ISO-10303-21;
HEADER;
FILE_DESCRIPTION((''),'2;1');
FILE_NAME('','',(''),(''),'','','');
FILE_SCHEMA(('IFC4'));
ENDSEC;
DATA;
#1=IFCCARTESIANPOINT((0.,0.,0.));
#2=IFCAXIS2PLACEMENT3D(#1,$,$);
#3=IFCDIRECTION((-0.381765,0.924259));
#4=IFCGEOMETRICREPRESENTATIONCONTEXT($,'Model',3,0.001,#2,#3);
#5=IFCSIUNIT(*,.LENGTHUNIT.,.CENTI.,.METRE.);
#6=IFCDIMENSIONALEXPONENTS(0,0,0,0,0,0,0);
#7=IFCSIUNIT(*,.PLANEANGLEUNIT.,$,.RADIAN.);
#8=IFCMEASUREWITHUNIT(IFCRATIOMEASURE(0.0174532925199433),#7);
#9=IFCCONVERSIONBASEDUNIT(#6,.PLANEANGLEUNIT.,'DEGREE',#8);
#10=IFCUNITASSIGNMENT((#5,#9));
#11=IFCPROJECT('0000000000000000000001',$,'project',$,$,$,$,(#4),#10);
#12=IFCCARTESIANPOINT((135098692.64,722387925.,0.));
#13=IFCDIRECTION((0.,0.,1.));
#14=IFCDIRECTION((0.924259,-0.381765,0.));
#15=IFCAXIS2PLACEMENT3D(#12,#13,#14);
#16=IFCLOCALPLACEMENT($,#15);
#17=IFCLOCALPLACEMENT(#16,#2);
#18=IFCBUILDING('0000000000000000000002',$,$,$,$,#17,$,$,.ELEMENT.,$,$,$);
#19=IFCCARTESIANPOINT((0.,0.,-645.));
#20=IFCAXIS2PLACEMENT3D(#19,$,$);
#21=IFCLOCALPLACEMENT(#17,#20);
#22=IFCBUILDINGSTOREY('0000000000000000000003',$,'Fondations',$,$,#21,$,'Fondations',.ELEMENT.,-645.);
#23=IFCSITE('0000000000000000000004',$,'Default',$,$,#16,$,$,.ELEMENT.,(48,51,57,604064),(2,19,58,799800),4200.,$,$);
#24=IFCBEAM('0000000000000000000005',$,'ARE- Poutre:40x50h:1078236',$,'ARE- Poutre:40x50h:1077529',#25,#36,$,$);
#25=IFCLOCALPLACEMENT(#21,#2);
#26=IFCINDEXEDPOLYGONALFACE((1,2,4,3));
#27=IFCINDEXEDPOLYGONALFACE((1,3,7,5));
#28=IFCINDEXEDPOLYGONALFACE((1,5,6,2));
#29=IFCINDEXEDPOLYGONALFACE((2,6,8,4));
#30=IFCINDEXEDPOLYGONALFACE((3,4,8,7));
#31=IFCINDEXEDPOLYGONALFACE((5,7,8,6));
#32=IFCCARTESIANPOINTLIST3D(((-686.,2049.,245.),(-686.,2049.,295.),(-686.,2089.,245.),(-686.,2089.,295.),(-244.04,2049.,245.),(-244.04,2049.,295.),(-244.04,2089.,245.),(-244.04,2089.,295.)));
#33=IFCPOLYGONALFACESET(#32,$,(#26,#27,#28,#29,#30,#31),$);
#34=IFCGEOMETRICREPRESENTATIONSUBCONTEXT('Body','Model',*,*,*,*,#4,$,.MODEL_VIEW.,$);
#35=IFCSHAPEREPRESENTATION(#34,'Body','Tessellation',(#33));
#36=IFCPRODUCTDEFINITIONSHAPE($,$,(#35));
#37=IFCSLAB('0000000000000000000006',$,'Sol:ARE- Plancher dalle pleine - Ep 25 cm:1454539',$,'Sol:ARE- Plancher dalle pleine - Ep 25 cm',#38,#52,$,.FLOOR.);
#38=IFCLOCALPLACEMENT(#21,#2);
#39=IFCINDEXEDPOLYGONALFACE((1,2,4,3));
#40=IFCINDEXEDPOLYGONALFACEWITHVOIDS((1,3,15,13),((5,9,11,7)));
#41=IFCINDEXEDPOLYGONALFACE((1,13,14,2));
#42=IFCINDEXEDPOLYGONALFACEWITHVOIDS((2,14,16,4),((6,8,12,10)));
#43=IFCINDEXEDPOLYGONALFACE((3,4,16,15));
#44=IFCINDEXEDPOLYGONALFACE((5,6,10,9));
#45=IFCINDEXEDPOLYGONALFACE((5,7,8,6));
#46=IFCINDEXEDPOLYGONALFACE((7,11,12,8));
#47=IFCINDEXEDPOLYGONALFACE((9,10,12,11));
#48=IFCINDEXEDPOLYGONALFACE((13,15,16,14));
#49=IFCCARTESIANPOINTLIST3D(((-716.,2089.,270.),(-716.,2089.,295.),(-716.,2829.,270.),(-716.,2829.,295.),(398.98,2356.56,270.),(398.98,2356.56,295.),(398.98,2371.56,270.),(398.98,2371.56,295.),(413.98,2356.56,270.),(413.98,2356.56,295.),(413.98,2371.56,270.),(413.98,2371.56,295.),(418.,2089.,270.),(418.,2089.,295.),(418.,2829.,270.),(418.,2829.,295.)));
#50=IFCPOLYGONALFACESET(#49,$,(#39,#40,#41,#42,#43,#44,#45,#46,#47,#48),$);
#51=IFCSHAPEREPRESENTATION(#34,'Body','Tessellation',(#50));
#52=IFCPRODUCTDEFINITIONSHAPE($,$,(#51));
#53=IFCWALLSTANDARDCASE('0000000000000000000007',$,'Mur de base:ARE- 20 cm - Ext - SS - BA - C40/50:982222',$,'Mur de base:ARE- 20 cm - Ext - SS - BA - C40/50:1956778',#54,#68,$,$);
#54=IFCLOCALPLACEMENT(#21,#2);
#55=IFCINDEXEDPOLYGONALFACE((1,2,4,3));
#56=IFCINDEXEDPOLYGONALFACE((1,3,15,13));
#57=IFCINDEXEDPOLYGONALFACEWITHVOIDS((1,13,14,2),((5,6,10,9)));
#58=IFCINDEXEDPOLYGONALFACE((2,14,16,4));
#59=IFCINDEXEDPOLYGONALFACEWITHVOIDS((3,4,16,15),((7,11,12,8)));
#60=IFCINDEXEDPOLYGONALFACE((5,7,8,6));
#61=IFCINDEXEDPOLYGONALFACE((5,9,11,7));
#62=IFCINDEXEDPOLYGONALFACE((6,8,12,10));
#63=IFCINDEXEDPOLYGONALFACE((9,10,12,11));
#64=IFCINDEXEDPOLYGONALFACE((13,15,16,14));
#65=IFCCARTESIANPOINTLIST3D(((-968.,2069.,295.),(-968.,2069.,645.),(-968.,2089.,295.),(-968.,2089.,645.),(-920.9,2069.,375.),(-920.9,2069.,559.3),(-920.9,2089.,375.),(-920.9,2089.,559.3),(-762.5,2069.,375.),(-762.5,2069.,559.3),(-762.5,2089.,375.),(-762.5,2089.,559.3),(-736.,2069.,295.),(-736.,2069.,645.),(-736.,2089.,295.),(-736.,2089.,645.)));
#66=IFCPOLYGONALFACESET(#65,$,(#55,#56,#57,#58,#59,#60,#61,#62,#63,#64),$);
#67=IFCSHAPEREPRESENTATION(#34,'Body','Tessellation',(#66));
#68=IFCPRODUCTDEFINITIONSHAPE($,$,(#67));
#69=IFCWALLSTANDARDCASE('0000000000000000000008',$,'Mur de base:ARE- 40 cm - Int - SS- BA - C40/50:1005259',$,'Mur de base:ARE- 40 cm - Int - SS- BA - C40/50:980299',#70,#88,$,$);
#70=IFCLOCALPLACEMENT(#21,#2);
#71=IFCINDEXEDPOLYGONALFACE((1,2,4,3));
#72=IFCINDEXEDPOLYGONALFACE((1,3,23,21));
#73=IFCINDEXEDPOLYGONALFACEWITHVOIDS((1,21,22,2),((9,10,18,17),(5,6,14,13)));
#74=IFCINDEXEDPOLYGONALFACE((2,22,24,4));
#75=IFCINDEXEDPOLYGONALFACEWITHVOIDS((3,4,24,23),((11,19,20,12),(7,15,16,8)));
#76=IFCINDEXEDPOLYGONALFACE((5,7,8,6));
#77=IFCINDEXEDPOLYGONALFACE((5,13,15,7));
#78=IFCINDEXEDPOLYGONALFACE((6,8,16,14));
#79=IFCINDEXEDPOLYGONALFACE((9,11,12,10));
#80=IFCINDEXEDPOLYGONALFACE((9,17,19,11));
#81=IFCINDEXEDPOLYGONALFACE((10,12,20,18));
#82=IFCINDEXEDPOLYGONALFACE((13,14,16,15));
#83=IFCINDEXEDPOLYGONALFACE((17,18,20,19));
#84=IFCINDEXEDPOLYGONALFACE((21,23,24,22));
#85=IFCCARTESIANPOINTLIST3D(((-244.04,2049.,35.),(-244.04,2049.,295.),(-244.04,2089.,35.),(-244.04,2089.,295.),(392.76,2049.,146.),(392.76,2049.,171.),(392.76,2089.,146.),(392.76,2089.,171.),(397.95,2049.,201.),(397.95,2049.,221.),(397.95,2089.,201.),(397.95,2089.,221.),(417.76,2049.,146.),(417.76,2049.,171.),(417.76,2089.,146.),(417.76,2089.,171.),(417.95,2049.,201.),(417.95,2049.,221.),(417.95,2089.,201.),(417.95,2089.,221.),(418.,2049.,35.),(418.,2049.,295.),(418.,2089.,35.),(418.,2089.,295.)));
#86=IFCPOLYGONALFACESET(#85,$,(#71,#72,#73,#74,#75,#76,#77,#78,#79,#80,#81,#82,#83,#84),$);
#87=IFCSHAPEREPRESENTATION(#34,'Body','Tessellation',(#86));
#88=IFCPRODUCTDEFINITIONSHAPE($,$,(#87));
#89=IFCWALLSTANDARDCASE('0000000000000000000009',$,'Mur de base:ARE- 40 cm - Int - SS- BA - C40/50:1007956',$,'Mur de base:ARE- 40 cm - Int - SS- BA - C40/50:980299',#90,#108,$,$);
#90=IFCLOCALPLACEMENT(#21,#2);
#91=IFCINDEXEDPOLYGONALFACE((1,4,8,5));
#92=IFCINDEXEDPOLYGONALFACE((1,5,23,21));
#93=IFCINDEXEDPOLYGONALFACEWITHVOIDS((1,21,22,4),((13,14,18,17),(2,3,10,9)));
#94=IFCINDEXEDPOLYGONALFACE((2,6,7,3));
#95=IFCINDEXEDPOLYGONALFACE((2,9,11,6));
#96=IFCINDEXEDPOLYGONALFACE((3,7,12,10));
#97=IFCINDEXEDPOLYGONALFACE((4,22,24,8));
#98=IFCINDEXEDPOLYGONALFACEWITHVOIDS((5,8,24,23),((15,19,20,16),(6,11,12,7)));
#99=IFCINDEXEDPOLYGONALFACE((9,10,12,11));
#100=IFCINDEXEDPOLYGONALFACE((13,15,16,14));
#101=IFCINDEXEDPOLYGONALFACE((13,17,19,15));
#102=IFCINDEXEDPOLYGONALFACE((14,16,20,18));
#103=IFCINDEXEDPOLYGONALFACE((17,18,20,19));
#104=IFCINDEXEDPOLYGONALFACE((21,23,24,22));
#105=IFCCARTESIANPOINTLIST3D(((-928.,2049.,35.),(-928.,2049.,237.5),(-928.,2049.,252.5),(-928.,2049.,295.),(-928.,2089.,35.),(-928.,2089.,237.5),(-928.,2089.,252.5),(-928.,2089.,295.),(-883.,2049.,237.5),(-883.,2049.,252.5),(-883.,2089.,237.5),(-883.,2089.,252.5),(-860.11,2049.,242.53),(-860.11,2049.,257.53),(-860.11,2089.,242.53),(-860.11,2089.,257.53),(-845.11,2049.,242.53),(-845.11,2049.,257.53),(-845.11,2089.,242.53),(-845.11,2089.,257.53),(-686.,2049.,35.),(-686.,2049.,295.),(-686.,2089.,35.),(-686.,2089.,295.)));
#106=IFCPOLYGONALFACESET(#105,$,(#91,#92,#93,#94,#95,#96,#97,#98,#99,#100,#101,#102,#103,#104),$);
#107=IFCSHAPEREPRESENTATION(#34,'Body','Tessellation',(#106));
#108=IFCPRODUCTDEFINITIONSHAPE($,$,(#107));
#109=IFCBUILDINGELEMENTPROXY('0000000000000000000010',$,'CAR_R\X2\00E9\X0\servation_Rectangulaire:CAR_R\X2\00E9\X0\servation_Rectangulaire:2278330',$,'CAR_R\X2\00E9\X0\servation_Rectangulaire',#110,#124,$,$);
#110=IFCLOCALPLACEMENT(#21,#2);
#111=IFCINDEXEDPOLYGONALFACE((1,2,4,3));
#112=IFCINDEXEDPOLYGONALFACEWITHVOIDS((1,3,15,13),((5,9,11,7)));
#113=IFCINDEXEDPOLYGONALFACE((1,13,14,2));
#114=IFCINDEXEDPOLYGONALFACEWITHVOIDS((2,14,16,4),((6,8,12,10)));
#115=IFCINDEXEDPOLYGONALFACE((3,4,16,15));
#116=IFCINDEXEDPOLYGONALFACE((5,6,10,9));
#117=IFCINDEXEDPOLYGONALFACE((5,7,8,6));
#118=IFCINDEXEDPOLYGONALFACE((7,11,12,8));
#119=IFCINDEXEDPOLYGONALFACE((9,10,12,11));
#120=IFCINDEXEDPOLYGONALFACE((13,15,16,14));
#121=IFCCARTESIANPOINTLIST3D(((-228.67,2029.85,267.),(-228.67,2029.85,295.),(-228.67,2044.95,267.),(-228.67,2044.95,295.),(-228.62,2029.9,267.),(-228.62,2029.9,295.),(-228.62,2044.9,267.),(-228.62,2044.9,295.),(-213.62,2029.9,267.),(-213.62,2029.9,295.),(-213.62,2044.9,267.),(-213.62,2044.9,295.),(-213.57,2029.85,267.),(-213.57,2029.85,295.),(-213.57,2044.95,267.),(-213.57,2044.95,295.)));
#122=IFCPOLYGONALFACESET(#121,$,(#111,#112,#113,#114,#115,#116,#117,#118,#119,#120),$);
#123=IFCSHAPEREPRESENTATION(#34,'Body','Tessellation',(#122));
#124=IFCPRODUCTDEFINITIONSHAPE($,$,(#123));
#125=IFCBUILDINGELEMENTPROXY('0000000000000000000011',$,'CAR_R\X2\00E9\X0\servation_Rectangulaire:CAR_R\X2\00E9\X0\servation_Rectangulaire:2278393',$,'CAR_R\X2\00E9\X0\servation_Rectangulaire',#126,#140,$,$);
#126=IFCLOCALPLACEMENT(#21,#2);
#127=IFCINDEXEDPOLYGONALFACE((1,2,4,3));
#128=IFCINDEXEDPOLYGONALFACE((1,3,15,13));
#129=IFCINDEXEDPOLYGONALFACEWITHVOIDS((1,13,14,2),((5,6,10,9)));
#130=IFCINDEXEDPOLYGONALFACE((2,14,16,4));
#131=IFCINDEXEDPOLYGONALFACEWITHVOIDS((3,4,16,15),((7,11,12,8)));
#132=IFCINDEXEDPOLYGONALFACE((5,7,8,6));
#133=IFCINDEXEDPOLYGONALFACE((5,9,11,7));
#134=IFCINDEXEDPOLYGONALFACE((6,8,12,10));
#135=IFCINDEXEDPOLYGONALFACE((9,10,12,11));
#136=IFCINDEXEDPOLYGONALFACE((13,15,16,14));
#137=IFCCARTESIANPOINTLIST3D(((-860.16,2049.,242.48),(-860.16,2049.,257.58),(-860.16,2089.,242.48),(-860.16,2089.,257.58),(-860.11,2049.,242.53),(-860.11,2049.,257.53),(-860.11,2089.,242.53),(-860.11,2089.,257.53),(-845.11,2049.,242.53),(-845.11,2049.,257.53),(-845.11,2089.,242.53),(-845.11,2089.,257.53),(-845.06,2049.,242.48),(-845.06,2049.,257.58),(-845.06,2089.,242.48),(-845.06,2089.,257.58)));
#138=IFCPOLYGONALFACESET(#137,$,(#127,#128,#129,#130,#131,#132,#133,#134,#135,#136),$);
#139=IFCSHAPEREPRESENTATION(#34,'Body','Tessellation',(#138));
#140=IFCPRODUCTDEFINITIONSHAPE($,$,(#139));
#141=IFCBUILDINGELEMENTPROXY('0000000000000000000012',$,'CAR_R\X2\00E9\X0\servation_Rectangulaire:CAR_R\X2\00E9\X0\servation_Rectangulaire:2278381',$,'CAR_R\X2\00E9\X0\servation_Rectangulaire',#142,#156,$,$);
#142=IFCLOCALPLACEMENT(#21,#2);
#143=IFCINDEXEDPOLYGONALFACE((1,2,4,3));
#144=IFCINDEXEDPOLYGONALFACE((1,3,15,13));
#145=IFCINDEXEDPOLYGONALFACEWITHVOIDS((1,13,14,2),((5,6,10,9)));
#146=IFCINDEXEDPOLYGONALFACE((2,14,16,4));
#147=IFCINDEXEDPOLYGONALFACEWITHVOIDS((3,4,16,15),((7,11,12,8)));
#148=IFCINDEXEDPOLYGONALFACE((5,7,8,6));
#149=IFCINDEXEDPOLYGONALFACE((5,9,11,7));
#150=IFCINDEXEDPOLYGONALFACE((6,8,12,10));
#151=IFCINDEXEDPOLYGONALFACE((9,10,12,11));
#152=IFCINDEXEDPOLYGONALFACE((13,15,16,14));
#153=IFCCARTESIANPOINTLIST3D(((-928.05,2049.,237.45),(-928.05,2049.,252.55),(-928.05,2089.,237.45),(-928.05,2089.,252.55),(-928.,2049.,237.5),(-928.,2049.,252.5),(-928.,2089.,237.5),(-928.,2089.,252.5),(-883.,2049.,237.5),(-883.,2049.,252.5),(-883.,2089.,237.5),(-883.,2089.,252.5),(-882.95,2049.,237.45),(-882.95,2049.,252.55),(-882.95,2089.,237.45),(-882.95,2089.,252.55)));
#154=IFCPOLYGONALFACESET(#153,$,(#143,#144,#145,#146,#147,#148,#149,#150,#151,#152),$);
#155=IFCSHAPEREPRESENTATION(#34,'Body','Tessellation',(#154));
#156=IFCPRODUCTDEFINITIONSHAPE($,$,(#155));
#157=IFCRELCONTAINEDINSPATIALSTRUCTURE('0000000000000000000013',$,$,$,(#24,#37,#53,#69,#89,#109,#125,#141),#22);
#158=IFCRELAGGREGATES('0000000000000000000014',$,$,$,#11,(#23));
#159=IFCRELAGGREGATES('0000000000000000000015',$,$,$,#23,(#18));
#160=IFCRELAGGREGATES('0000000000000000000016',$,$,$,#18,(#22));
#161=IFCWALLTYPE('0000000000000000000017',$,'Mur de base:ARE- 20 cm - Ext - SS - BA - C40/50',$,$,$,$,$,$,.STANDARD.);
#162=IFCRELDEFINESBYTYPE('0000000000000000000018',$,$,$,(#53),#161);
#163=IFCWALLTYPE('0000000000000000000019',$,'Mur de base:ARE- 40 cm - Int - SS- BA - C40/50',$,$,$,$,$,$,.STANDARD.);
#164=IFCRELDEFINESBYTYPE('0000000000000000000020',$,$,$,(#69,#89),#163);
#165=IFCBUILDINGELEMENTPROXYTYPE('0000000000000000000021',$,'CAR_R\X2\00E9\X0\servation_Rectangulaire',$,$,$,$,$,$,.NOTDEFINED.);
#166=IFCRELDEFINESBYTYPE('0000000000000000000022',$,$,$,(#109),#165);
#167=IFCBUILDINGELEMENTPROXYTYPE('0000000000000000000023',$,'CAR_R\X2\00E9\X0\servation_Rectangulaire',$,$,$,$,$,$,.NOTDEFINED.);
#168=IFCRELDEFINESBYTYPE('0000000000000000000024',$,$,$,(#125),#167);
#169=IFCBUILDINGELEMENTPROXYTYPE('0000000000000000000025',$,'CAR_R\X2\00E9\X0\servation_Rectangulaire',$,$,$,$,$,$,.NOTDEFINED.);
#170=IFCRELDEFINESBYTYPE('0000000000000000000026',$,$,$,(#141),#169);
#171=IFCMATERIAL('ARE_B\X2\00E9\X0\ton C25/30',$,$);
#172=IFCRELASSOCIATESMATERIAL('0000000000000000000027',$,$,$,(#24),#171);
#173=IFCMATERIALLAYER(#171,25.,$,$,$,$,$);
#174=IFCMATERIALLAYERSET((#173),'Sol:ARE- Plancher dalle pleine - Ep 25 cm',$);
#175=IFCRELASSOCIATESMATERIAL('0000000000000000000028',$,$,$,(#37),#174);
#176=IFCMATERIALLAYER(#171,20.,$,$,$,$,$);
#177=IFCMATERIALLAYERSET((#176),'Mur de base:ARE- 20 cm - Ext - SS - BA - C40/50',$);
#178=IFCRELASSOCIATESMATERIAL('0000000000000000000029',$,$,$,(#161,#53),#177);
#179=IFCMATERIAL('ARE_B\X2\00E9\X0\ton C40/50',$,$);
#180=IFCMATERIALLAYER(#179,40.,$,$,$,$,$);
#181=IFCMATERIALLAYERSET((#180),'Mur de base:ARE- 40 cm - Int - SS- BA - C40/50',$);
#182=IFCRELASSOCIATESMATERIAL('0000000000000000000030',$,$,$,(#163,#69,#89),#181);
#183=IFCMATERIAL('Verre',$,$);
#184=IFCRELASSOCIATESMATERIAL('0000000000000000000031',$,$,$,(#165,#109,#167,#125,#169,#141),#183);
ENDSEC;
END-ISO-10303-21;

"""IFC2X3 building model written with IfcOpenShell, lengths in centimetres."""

from ifc_helpers import new_model, entity, si_unit, converted_unit, direction, frame, frame_2d, origin, origin_2d_with_axis, place, context, subcontext, project, spatial, polyline, rectangle, outline, extrude, source, transform, mapped, material, layer, layer_set, layer_usage, type_object, type_shapes, element, save


model = new_model("IFC2X3")

# Units and contexts
model_context = context("Model", 3, precision=0.001, world=origin(), true_north=direction((-0.381765, 0.924259)))
body_context = subcontext(model_context, "Body", "Model", "MODEL_VIEW")
ifc_project = project(units=[si_unit("LENGTHUNIT", "METRE", prefix="CENTI"), converted_unit("PLANEANGLEUNIT", "DEGREE", entity("IfcRatioMeasure", 0.0174532925199433), si_unit("PLANEANGLEUNIT", "RADIAN"), dimensions=[0, 0, 0, 0, 0, 0, 0])], contexts=[model_context])

# Site, building, storey
site_placement = place(None, frame((135098692.64, 722387925.0, 0.0), z_axis=(0.0, 0.0, 1.0), x_axis=(0.924259, -0.381765, 0.0)))
site = spatial("IfcSite", under=ifc_project, at=site_placement, Name="Default", CompositionType="ELEMENT", RefLatitude=(48, 51, 57, 604064), RefLongitude=(2, 19, 58, 799800), RefElevation=4200.0)
building_placement = place(site_placement, origin())
building = spatial("IfcBuilding", under=site, at=building_placement, CompositionType="ELEMENT")
storey_placement = place(building_placement, frame((0.0, 0.0, -645.0)))
storey = spatial("IfcBuildingStorey", under=building, at=storey_placement, Name="Fondations", LongName="Fondations", CompositionType="ELEMENT", Elevation=-645.0)

# Beam
ifc_material_1 = material(Name="ARE_Béton C25/30")
beam_placement = place(storey_placement, frame((-244.04, 2069.0, 295.0), z_axis=(0.0, 0.0, 1.0), x_axis=(-1.0, 0.0, 0.0)))
element("IfcBeam", 1, at=beam_placement, inside=storey, material=ifc_material_1, Name="ARE- Poutre:40x50h:1078236", ObjectType="ARE- Poutre:40x50h:1077529", context=body_context, shape_type="SweptSolid", body=[
    extrude(rectangle(XDim=50.0, YDim=40.0, at=frame_2d((0.0, 0.0), x_axis=(1.0, 0.0))), frame((0.0, 0.0, -25.0), z_axis=(1.0, 0.0, 0.0), x_axis=(0.0, 0.0, -1.0)), (0.0, 0.0, 1.0), 441.96),
])

# Slab, opening
ifc_layer_1 = layer(ifc_material_1, 25.0)
ifc_layer_set_1 = layer_set([ifc_layer_1], Name="Sol:ARE- Plancher dalle pleine - Ep 25 cm")
ifc_layer_usage_1 = layer_usage(ifc_layer_set_1, "AXIS3", "POSITIVE", 0.0)
slab_placement = place(storey_placement, frame((-716.0, 2089.0, 270.0)))
slab = element("IfcSlab", 2, at=slab_placement, inside=storey, material=ifc_layer_usage_1, Name="Sol:ARE- Plancher dalle pleine - Ep 25 cm:1454539", ObjectType="Sol:ARE- Plancher dalle pleine - Ep 25 cm", PredefinedType="FLOOR", context=body_context, shape_type="SweptSolid", body=[
    extrude(rectangle(XDim=1134.0, YDim=740.0, at=frame_2d((0.0, 0.0), x_axis=(-1.0, 0.0))), frame((567.0, 370.0, 25.0), z_axis=(0.0, 0.0, -1.0), x_axis=(-1.0, 0.0, 0.0)), (0.0, 0.0, 1.0), 25.0),
])
opening_1_placement = place(slab_placement, origin())
element("IfcOpeningElement", 3, at=opening_1_placement, cuts=slab, ObjectType="Opening", context=body_context, shape_type="SweptSolid", body=[
    extrude(rectangle(XDim=15.0, YDim=15.0, at=origin_2d_with_axis()), frame((1122.48, 275.06, 0.0), z_axis=(0.0, 0.0, 1.0), x_axis=(-1.0, 0.0, 0.0)), (0.0, 0.0, 1.0), 25.0),
])

# Wall, opening
ifc_layer_2 = layer(ifc_material_1, 20.0)
ifc_layer_set_2 = layer_set([ifc_layer_2], Name="Mur de base:ARE- 20 cm - Ext - SS - BA - C40/50")
ifc_layer_usage_2 = layer_usage(ifc_layer_set_2, "AXIS2", "NEGATIVE", 10.0)
wall_type_1 = type_object("IfcWallType", Name="Mur de base:ARE- 20 cm - Ext - SS - BA - C40/50", PredefinedType="STANDARD", material=ifc_layer_set_2)
wall_1_placement = place(storey_placement, frame((-736.0, 2079.0, 295.0), z_axis=(0.0, 0.0, 1.0), x_axis=(-1.0, 0.0, 0.0)))
wall_1 = element("IfcWallStandardCase", 4, at=wall_1_placement, inside=storey, type_object=wall_type_1, material=ifc_layer_usage_2, Name="Mur de base:ARE- 20 cm - Ext - SS - BA - C40/50:982222", ObjectType="Mur de base:ARE- 20 cm - Ext - SS - BA - C40/50:1956778", context=body_context, shape_type="SweptSolid", body=[
    extrude(rectangle(XDim=232.0, YDim=20.0, at=frame_2d((116.0, 0.0), x_axis=(-1.0, 0.0))), origin(), (0.0, 0.0, 1.0), 350.0),
])
opening_2_placement = place(wall_1_placement, frame((-736.0, 2079.0, -295.0), z_axis=(0.0, 0.0, 1.0), x_axis=(-1.0, 0.0, 0.0)))
element("IfcOpeningElement", 5, at=opening_2_placement, cuts=wall_1, ObjectType="Opening", context=body_context, shape_type="SweptSolid", body=[
    extrude(rectangle(XDim=184.3, YDim=158.4, at=frame_2d((0.0, 0.0), x_axis=(0.0, 1.0))), frame((-841.7, 2241.4, 467.15), z_axis=(0.0, -1.0, 0.0), x_axis=(-1.0, 0.0, 0.0)), (0.0, 0.0, 1.0), 304.8),
])

# Walls, openings
ifc_material_2 = material(Name="ARE_Béton C40/50")
ifc_layer_3 = layer(ifc_material_2, 40.0)
ifc_layer_set_3 = layer_set([ifc_layer_3], Name="Mur de base:ARE- 40 cm - Int - SS- BA - C40/50")
ifc_layer_usage_3 = layer_usage(ifc_layer_set_3, "AXIS2", "NEGATIVE", 20.0)
wall_type_2 = type_object("IfcWallType", Name="Mur de base:ARE- 40 cm - Int - SS- BA - C40/50", PredefinedType="STANDARD", material=ifc_layer_set_3)
wall_2_placement = place(storey_placement, frame((-244.04, 2069.0, 35.0)))
wall_2 = element("IfcWallStandardCase", 6, at=wall_2_placement, inside=storey, type_object=wall_type_2, material=ifc_layer_usage_3, Name="Mur de base:ARE- 40 cm - Int - SS- BA - C40/50:1005259", ObjectType="Mur de base:ARE- 40 cm - Int - SS- BA - C40/50:980299", context=body_context, shape_type="SweptSolid", body=[
    extrude(rectangle(XDim=662.04, YDim=40.0, at=frame_2d((331.02, 0.0), x_axis=(-1.0, 0.0))), origin(), (0.0, 0.0, 1.0), 260.0),
])
opening_3_placement = place(wall_2_placement, origin())
element("IfcOpeningElement", 7, at=opening_3_placement, cuts=wall_2, ObjectType="Opening", context=body_context, shape_type="SweptSolid", body=[
    extrude(rectangle(XDim=25.0, YDim=25.0, at=frame_2d((0.0, 0.0), x_axis=(1.0, 0.0))), frame((649.31, -20.0, 123.5), z_axis=(0.0, 1.0, 0.0), x_axis=(0.0, 0.0, -1.0)), (0.0, 0.0, 1.0), 40.0),
])
opening_4_placement = place(wall_2_placement, origin())
element("IfcOpeningElement", 8, at=opening_4_placement, cuts=wall_2, ObjectType="Opening", context=body_context, shape_type="SweptSolid", body=[
    extrude(rectangle(XDim=20.0, YDim=20.0, at=origin_2d_with_axis()), frame((651.99, -20.0, 176.0), z_axis=(0.0, 1.0, 0.0), x_axis=(0.0, 0.0, -1.0)), (0.0, 0.0, 1.0), 40.0),
])
ifc_layer_usage_4 = layer_usage(ifc_layer_set_3, "AXIS2", "NEGATIVE", 20.0)
wall_3_placement = place(storey_placement, frame((-686.0, 2069.0, 35.0), z_axis=(0.0, 0.0, 1.0), x_axis=(-1.0, 0.0, 0.0)))
wall_3 = element("IfcWallStandardCase", 9, at=wall_3_placement, inside=storey, type_object=wall_type_2, material=ifc_layer_usage_4, Name="Mur de base:ARE- 40 cm - Int - SS- BA - C40/50:1007956", ObjectType="Mur de base:ARE- 40 cm - Int - SS- BA - C40/50:980299", context=body_context, shape_type="SweptSolid", body=[
    extrude(rectangle(XDim=242.0, YDim=40.0, at=frame_2d((121.0, 0.0), x_axis=(-1.0, 0.0))), origin(), (0.0, 0.0, 1.0), 260.0),
])
opening_5_placement = place(wall_3_placement, origin())
element("IfcOpeningElement", 10, at=opening_5_placement, cuts=wall_3, ObjectType="Opening", context=body_context, shape_type="SweptSolid", body=[
    extrude(rectangle(XDim=15.0, YDim=45.0, at=frame_2d((0.0, 0.0), x_axis=(1.0, 0.0))), frame((219.5, -20.0, 210.0), z_axis=(0.0, 1.0, 0.0), x_axis=(0.0, 0.0, -1.0)), (0.0, 0.0, 1.0), 40.0),
])
opening_6_placement = place(wall_3_placement, origin())
element("IfcOpeningElement", 11, at=opening_6_placement, cuts=wall_3, ObjectType="Opening", context=body_context, shape_type="SweptSolid", body=[
    extrude(rectangle(XDim=15.0, YDim=15.0, at=frame_2d((0.0, 0.0), x_axis=(1.0, 0.0))), frame((166.61, -20.0, 215.03), z_axis=(0.0, 1.0, 0.0), x_axis=(0.0, 0.0, -1.0)), (0.0, 0.0, 1.0), 40.0),
])

# Building element proxies
ifc_material_3 = material(Name="Verre")
building_element_proxy_type_1 = type_object("IfcBuildingElementProxyType", Name="CAR_Réservation_Rectangulaire", PredefinedType="NOTDEFINED", material=ifc_material_3)
shared_shape_1 = source(origin(), body_context, "Body", "SweptSolid", [
    extrude(outline(polyline([(-7.55, -7.55), (7.55, -7.55), (7.55, 7.55), (-7.55, 7.55), (-7.55, -7.55)]), holes=[polyline([(7.5, -7.5), (-7.5, -7.5), (-7.5, 7.5), (7.5, 7.5), (7.5, -7.5)])]), frame((0.0, 0.0, -28.0), z_axis=(0.0, 0.0, 1.0), x_axis=(-1.0, 0.0, 0.0)), (0.0, 0.0, 1.0), 28.0),
])
type_shapes(building_element_proxy_type_1, [shared_shape_1])
proxy_1_placement = place(storey_placement, frame((-221.12, 2037.4, 295.0), z_axis=(0.0, 0.0, 1.0), x_axis=(0.0, 1.0, 0.0)))
element("IfcBuildingElementProxy", 12, at=proxy_1_placement, inside=storey, type_object=building_element_proxy_type_1, material=ifc_material_3, Name="CAR_Réservation_Rectangulaire:CAR_Réservation_Rectangulaire:2278330", ObjectType="CAR_Réservation_Rectangulaire", context=body_context, shape_type="MappedRepresentation", body=[
    mapped(shared_shape_1, transform((0.0, 0.0, 0.0), scale=1.0)),
])
building_element_proxy_type_2 = type_object("IfcBuildingElementProxyType", Name="CAR_Réservation_Rectangulaire", PredefinedType="NOTDEFINED", material=ifc_material_3)
shared_shape_2 = source(origin(), body_context, "Body", "SweptSolid", [
    extrude(outline(polyline([(-7.55, -7.55), (7.55, -7.55), (7.55, 7.55), (-7.55, 7.55), (-7.55, -7.55)]), holes=[polyline([(7.5, -7.5), (-7.5, -7.5), (-7.5, 7.5), (7.5, 7.5), (7.5, -7.5)])]), frame((0.0, 0.0, -40.0), z_axis=(0.0, 0.0, 1.0), x_axis=(-1.0, 0.0, 0.0)), (0.0, 0.0, 1.0), 40.0),
])
type_shapes(building_element_proxy_type_2, [shared_shape_2])
proxy_2_placement = place(storey_placement, frame((-852.61, 2089.0, 250.03), z_axis=(0.0, 1.0, 0.0), x_axis=(-1.0, 0.0, 0.0)))
element("IfcBuildingElementProxy", 13, at=proxy_2_placement, inside=storey, type_object=building_element_proxy_type_2, material=ifc_material_3, Name="CAR_Réservation_Rectangulaire:CAR_Réservation_Rectangulaire:2278393", ObjectType="CAR_Réservation_Rectangulaire", context=body_context, shape_type="MappedRepresentation", body=[
    mapped(shared_shape_2, transform((0.0, 0.0, 0.0), scale=1.0)),
])
building_element_proxy_type_3 = type_object("IfcBuildingElementProxyType", Name="CAR_Réservation_Rectangulaire", PredefinedType="NOTDEFINED", material=ifc_material_3)
shared_shape_3 = source(origin(), body_context, "Body", "SweptSolid", [
    extrude(outline(polyline([(-22.55, -7.55), (22.55, -7.55), (22.55, 7.55), (-22.55, 7.55), (-22.55, -7.55)]), holes=[polyline([(22.5, -7.5), (-22.5, -7.5), (-22.5, 7.5), (22.5, 7.5), (22.5, -7.5)])]), frame((0.0, 0.0, -40.0), z_axis=(0.0, 0.0, 1.0), x_axis=(-1.0, 0.0, 0.0)), (0.0, 0.0, 1.0), 40.0),
])
type_shapes(building_element_proxy_type_3, [shared_shape_3])
proxy_3_placement = place(storey_placement, frame((-905.5, 2089.0, 245.0), z_axis=(0.0, 1.0, 0.0), x_axis=(-1.0, 0.0, 0.0)))
element("IfcBuildingElementProxy", 14, at=proxy_3_placement, inside=storey, type_object=building_element_proxy_type_3, material=ifc_material_3, Name="CAR_Réservation_Rectangulaire:CAR_Réservation_Rectangulaire:2278381", ObjectType="CAR_Réservation_Rectangulaire", context=body_context, shape_type="MappedRepresentation", body=[
    mapped(shared_shape_3, transform((0.0, 0.0, 0.0), scale=1.0)),
])

save(model, "model.ifc")
